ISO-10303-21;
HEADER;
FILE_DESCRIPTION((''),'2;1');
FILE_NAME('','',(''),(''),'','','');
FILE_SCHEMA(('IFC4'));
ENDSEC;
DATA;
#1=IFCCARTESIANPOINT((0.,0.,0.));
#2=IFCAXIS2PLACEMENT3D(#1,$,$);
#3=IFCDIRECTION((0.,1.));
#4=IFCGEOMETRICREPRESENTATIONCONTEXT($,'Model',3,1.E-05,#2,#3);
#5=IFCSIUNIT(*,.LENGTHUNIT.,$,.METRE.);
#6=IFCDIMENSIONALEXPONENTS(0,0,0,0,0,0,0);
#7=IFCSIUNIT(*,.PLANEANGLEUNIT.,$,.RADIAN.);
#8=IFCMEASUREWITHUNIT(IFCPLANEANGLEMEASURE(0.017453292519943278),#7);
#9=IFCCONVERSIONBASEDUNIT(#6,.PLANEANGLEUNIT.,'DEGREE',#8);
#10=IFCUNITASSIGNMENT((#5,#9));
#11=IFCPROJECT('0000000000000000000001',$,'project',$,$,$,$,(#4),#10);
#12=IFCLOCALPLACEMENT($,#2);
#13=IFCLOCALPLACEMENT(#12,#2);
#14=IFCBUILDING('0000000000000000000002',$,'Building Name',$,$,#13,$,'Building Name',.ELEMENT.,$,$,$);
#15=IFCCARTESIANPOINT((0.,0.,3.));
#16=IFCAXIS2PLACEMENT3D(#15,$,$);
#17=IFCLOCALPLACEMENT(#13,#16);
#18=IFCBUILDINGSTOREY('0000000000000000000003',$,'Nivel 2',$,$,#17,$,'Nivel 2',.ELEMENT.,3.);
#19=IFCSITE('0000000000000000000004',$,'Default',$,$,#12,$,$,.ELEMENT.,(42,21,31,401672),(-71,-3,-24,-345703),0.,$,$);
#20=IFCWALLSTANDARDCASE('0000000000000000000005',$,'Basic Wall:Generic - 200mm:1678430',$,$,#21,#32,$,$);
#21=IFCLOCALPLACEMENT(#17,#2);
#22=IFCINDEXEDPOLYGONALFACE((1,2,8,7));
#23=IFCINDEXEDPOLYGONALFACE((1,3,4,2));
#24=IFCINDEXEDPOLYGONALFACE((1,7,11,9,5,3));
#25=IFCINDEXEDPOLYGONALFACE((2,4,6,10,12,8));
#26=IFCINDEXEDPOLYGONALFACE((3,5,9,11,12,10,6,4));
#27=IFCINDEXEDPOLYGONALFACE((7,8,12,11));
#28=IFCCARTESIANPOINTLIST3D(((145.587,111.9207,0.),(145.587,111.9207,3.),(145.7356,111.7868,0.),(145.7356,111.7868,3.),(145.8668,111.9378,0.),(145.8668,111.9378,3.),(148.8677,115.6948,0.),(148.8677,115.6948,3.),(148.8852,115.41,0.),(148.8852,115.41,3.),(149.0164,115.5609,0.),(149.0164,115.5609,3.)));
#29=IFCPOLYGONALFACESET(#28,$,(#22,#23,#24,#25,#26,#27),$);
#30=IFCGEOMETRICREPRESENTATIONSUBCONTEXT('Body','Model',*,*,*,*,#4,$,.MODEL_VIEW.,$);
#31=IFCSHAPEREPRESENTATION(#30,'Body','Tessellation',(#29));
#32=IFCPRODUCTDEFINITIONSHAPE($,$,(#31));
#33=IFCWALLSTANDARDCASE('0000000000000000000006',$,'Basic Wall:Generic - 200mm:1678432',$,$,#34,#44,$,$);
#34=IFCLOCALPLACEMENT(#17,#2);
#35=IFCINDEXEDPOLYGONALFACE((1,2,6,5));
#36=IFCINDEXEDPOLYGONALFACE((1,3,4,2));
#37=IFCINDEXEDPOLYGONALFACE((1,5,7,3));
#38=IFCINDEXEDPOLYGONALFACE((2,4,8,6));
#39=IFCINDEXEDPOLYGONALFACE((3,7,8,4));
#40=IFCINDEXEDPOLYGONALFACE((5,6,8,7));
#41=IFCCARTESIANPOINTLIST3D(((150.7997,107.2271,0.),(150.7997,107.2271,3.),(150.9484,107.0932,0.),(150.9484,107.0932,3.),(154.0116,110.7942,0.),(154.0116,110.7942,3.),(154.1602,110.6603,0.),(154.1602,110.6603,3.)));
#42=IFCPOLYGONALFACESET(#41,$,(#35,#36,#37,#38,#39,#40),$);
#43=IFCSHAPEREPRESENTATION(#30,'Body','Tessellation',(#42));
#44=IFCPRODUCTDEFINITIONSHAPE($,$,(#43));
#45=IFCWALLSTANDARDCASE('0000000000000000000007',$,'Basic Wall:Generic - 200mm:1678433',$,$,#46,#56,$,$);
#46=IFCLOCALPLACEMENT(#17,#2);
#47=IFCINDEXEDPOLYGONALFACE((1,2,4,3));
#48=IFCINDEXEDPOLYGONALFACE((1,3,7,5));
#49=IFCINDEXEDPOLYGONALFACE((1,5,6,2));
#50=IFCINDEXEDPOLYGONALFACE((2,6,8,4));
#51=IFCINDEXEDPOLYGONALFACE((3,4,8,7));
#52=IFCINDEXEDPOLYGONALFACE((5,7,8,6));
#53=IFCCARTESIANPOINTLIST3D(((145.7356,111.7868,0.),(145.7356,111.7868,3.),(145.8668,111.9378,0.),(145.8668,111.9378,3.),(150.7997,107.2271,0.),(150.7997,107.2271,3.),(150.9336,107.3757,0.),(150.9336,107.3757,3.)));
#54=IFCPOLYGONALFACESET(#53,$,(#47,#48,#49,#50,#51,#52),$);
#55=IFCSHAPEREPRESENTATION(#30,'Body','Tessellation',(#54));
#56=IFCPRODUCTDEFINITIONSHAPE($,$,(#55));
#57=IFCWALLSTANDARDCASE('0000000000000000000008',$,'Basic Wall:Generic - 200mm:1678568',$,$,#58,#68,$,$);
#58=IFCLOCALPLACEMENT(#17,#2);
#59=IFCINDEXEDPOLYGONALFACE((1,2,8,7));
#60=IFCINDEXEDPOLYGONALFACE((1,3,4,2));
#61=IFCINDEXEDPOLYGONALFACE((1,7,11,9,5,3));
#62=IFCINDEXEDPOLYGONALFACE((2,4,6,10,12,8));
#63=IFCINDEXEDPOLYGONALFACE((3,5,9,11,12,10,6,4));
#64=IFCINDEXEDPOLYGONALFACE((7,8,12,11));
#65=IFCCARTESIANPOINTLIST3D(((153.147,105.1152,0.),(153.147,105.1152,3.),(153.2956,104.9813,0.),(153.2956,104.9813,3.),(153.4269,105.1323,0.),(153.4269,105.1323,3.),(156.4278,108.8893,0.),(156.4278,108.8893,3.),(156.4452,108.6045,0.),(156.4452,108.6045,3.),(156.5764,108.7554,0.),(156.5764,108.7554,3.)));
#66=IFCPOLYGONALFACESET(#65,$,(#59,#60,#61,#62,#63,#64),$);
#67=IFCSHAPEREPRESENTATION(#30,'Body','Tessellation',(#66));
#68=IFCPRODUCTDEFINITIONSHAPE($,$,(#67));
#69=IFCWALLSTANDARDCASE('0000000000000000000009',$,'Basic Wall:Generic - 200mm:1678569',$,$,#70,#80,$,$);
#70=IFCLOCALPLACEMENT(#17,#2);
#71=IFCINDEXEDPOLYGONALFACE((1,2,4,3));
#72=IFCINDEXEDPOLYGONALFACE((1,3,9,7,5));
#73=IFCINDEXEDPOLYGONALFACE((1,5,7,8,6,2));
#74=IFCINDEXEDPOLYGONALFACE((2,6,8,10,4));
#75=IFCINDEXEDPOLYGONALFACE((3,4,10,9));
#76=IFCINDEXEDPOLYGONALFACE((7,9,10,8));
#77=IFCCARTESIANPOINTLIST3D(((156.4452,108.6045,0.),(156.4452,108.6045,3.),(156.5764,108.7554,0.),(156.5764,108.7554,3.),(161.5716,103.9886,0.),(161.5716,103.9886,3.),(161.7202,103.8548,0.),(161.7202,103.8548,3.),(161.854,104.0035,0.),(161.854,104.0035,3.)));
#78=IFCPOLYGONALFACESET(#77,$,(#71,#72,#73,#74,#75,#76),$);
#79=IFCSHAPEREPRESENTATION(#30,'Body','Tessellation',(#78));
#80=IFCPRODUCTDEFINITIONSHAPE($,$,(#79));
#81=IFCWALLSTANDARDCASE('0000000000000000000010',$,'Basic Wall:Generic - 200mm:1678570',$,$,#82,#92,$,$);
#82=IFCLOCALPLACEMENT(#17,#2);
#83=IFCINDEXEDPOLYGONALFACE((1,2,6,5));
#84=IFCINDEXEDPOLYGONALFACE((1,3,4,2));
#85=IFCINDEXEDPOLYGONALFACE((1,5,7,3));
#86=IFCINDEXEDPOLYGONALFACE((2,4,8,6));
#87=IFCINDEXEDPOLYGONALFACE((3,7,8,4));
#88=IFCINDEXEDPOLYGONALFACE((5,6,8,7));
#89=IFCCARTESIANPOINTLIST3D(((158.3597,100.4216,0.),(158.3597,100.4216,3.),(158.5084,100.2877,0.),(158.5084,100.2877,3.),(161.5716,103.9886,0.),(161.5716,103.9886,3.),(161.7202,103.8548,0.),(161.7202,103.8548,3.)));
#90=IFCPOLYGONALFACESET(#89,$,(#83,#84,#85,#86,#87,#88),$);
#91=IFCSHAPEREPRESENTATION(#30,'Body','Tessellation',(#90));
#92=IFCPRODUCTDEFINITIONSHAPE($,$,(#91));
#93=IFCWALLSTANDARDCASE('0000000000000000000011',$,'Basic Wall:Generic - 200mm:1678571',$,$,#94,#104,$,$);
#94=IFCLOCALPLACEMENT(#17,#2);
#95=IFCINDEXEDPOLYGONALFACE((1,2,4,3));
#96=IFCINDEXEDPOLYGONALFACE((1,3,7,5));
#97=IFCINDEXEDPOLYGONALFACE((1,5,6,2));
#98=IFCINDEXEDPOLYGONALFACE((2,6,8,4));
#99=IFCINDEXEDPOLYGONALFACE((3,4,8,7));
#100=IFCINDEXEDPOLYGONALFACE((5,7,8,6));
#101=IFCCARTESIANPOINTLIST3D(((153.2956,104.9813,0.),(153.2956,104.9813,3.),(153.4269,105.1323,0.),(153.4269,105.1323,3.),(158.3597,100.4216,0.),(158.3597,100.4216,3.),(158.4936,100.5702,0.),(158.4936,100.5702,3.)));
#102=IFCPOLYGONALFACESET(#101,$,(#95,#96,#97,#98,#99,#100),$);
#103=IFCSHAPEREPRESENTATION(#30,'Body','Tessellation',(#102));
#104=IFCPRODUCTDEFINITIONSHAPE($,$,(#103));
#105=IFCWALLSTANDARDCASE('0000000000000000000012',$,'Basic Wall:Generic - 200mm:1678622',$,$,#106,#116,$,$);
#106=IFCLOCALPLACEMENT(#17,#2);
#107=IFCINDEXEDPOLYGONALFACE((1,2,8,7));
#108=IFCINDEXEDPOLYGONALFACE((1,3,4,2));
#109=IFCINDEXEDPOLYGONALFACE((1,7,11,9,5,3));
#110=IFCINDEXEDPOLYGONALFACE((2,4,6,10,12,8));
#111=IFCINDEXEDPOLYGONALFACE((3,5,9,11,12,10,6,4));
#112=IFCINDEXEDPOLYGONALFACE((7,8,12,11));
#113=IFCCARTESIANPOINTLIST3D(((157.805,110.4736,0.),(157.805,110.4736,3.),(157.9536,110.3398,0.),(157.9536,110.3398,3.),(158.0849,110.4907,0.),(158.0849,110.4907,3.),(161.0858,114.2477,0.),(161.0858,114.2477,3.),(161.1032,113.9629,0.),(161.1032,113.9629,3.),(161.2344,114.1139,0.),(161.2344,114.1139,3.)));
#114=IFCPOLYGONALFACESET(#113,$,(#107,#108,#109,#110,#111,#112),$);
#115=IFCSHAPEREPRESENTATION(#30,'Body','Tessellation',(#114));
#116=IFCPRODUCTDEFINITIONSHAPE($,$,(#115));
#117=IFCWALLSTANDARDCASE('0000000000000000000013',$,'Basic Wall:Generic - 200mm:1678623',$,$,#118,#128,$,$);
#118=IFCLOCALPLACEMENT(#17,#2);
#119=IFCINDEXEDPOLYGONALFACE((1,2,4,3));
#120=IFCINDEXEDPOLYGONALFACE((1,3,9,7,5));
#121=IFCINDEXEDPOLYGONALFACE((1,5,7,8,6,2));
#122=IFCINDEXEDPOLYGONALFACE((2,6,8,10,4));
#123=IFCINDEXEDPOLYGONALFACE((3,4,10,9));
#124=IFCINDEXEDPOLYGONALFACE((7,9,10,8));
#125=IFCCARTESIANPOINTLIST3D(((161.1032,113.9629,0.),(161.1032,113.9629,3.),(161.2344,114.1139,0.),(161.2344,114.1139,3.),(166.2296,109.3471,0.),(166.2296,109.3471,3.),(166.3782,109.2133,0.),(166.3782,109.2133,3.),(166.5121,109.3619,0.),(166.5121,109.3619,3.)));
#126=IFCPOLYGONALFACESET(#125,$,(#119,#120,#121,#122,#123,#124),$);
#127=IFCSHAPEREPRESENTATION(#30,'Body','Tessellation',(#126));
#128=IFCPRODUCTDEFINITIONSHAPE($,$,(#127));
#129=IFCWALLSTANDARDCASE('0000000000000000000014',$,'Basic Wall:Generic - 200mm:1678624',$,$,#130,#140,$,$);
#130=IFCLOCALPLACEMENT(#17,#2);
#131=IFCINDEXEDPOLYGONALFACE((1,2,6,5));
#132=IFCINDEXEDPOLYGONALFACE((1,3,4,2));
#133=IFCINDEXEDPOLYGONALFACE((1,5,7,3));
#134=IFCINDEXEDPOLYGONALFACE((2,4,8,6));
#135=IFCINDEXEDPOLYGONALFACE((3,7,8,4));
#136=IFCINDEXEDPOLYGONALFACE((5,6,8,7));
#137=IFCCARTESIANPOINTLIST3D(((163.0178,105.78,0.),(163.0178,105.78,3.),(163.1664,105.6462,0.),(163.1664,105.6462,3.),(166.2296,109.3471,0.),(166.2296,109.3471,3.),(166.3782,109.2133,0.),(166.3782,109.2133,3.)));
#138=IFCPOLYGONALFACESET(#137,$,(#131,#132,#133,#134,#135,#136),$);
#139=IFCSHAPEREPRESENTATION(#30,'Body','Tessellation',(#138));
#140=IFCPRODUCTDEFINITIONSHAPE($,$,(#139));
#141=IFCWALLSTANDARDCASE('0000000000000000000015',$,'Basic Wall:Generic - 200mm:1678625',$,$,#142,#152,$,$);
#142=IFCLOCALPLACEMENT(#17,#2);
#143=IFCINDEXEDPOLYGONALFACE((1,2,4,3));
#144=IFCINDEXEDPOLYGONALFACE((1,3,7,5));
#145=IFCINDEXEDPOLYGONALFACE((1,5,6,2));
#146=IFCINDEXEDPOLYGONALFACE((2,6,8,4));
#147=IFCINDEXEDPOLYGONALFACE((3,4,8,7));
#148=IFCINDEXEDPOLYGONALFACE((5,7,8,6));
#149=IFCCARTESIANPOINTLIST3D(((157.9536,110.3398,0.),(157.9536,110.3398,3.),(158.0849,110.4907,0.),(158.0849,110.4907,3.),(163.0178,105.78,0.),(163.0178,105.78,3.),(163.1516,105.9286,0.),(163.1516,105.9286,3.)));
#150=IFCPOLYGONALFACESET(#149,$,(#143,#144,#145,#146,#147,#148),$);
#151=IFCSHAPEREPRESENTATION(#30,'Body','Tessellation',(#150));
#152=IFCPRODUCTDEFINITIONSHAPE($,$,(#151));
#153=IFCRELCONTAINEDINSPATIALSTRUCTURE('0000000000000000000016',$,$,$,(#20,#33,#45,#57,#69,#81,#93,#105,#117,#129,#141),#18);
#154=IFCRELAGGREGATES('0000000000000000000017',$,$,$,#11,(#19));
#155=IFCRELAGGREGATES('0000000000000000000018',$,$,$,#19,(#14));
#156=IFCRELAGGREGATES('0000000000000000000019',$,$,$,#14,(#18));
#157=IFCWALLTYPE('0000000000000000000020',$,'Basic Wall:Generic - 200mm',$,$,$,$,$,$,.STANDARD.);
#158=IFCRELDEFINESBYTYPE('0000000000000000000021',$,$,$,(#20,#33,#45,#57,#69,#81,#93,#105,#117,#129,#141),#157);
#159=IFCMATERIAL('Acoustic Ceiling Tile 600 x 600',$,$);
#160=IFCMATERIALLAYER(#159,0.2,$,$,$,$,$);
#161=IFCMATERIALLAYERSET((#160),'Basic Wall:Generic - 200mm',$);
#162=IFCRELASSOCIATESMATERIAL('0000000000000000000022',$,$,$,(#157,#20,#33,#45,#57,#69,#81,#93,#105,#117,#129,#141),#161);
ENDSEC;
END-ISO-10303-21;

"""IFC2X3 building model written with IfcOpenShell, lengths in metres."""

from ifc_helpers import new_model, entity, si_unit, converted_unit, direction, frame, frame_2d, origin, place, context, subcontext, project, spatial, polyline, rectangle, outline, extrude, material, layer, layer_set, layer_usage, type_object, element, save


model = new_model("IFC2X3")

# Units and contexts
model_context = context("Model", 3, precision=1e-05, world=origin(), true_north=direction((0.0, 1.0)))
body_context = subcontext(model_context, "Body", "Model", "MODEL_VIEW")
ifc_project = project(units=[si_unit("LENGTHUNIT", "METRE"), converted_unit("PLANEANGLEUNIT", "DEGREE", entity("IfcPlaneAngleMeasure", 0.017453292519943278), si_unit("PLANEANGLEUNIT", "RADIAN"), dimensions=[0, 0, 0, 0, 0, 0, 0])], contexts=[model_context])

# Site, building, storey
site_placement = place(None, origin())
site = spatial("IfcSite", under=ifc_project, at=site_placement, Name="Default", CompositionType="ELEMENT", RefLatitude=(42, 21, 31, 401672), RefLongitude=(-71, -3, -24, -345703), RefElevation=0.0)
building_placement = place(site_placement, origin())
building = spatial("IfcBuilding", under=site, at=building_placement, Name="Building Name", LongName="Building Name", CompositionType="ELEMENT")
storey_placement = place(building_placement, frame((0.0, 0.0, 3.0)))
storey = spatial("IfcBuildingStorey", under=building, at=storey_placement, Name="Nivel 2", LongName="Nivel 2", CompositionType="ELEMENT", Elevation=3.0)

# Shared definitions
ifc_material_1 = material(Name="Acoustic Ceiling Tile 600 x 600")
ifc_layer_1 = layer(ifc_material_1, 0.2)
ifc_layer_set_1 = layer_set([ifc_layer_1], Name="Basic Wall:Generic - 200mm")
wall_type_1 = type_object("IfcWallType", Name="Basic Wall:Generic - 200mm", PredefinedType="STANDARD", material=ifc_layer_set_1)

# Walls
ifc_layer_usage_1 = layer_usage(ifc_layer_set_1, "AXIS2", "NEGATIVE", 0.1)
wall_1_placement = place(storey_placement, frame((145.6601, 111.8524, 0.0), z_axis=(0.0, 0.0, 1.0), x_axis=(0.656059, 0.75471, 0.0)))
element("IfcWallStandardCase", 1, at=wall_1_placement, inside=storey, type_object=wall_type_1, material=ifc_layer_usage_1, Name="Basic Wall:Generic - 200mm:1678430", context=body_context, shape_type="SweptSolid", body=[
    extrude(outline(polyline([(5.0008, -0.1), (5.0043, 0.1), (0.0035, 0.1), (0.0, -0.1), (0.2, -0.1), (4.8007, -0.1), (5.0008, -0.1)])), origin(), (0.0, 0.0, 1.0), 3.0),
])
ifc_layer_usage_2 = layer_usage(ifc_layer_set_1, "AXIS2", "NEGATIVE", 0.1)
wall_2_placement = place(storey_placement, frame((154.0859, 110.7272, 0.0), z_axis=(0.0, 0.0, 1.0), x_axis=(-0.669131, -0.743145, 0.0)))
element("IfcWallStandardCase", 2, at=wall_2_placement, inside=storey, type_object=wall_type_1, material=ifc_layer_usage_2, Name="Basic Wall:Generic - 200mm:1678432", context=body_context, shape_type="SweptSolid", body=[
    extrude(rectangle(XDim=4.8, YDim=0.2, at=frame_2d((2.4, 0.0), x_axis=(-1.0, 0.0))), origin(), (0.0, 0.0, 1.0), 3.0),
])
ifc_layer_usage_3 = layer_usage(ifc_layer_set_1, "AXIS2", "NEGATIVE", 0.1)
wall_3_placement = place(storey_placement, frame((150.8666, 107.3014, 0.0), z_axis=(0.0, 0.0, 1.0), x_axis=(-0.743145, 0.669131, 0.0)))
element("IfcWallStandardCase", 3, at=wall_3_placement, inside=storey, type_object=wall_type_1, material=ifc_layer_usage_3, Name="Basic Wall:Generic - 200mm:1678433", context=body_context, shape_type="SweptSolid", body=[
    extrude(outline(polyline([(6.8179, -0.1), (6.8145, 0.1), (0.0, 0.1), (0.0, -0.1), (6.8179, -0.1)])), origin(), (0.0, 0.0, 1.0), 3.0),
])
ifc_layer_usage_4 = layer_usage(ifc_layer_set_1, "AXIS2", "NEGATIVE", 0.1)
wall_4_placement = place(storey_placement, frame((153.2202, 105.0469, 0.0), z_axis=(0.0, 0.0, 1.0), x_axis=(0.656059, 0.75471, 0.0)))
element("IfcWallStandardCase", 4, at=wall_4_placement, inside=storey, type_object=wall_type_1, material=ifc_layer_usage_4, Name="Basic Wall:Generic - 200mm:1678568", context=body_context, shape_type="SweptSolid", body=[
    extrude(outline(polyline([(5.0008, -0.1), (5.0043, 0.1), (0.0035, 0.1), (0.0, -0.1), (0.2, -0.1), (4.8007, -0.1), (5.0008, -0.1)])), origin(), (0.0, 0.0, 1.0), 3.0),
])
ifc_layer_usage_5 = layer_usage(ifc_layer_set_1, "AXIS2", "NEGATIVE", 0.1)
wall_5_placement = place(storey_placement, frame((156.5095, 108.6811, 0.0), z_axis=(0.0, 0.0, 1.0), x_axis=(0.743145, -0.669131, 0.0)))
element("IfcWallStandardCase", 5, at=wall_5_placement, inside=storey, type_object=wall_type_1, material=ifc_layer_usage_5, Name="Basic Wall:Generic - 200mm:1678569", context=body_context, shape_type="SweptSolid", body=[
    extrude(outline(polyline([(7.1017, -0.1), (7.1017, 0.1), (0.0, 0.1), (0.0035, -0.1), (6.9017, -0.1), (7.1017, -0.1)])), origin(), (0.0, 0.0, 1.0), 3.0),
])
ifc_layer_usage_6 = layer_usage(ifc_layer_set_1, "AXIS2", "NEGATIVE", 0.1)
wall_6_placement = place(storey_placement, frame((161.6459, 103.9217, 0.0), z_axis=(0.0, 0.0, 1.0), x_axis=(-0.669131, -0.743145, 0.0)))
element("IfcWallStandardCase", 6, at=wall_6_placement, inside=storey, type_object=wall_type_1, material=ifc_layer_usage_6, Name="Basic Wall:Generic - 200mm:1678570", context=body_context, shape_type="SweptSolid", body=[
    extrude(rectangle(XDim=4.8, YDim=0.2, at=frame_2d((2.4, 0.0), x_axis=(-1.0, 0.0))), origin(), (0.0, 0.0, 1.0), 3.0),
])
ifc_layer_usage_7 = layer_usage(ifc_layer_set_1, "AXIS2", "NEGATIVE", 0.1)
wall_7_placement = place(storey_placement, frame((158.4267, 100.4959, 0.0), z_axis=(0.0, 0.0, 1.0), x_axis=(-0.743145, 0.669131, 0.0)))
element("IfcWallStandardCase", 7, at=wall_7_placement, inside=storey, type_object=wall_type_1, material=ifc_layer_usage_7, Name="Basic Wall:Generic - 200mm:1678571", context=body_context, shape_type="SweptSolid", body=[
    extrude(outline(polyline([(6.8179, -0.1), (6.8145, 0.1), (0.0, 0.1), (0.0, -0.1), (6.8179, -0.1)])), origin(), (0.0, 0.0, 1.0), 3.0),
])
ifc_layer_usage_8 = layer_usage(ifc_layer_set_1, "AXIS2", "NEGATIVE", 0.1)
wall_8_placement = place(storey_placement, frame((157.8782, 110.4054, 0.0), z_axis=(0.0, 0.0, 1.0), x_axis=(0.656059, 0.75471, 0.0)))
element("IfcWallStandardCase", 8, at=wall_8_placement, inside=storey, type_object=wall_type_1, material=ifc_layer_usage_8, Name="Basic Wall:Generic - 200mm:1678622", context=body_context, shape_type="SweptSolid", body=[
    extrude(outline(polyline([(5.0008, -0.1), (5.0043, 0.1), (0.0035, 0.1), (0.0, -0.1), (0.2, -0.1), (4.8007, -0.1), (5.0008, -0.1)])), origin(), (0.0, 0.0, 1.0), 3.0),
])
ifc_layer_usage_9 = layer_usage(ifc_layer_set_1, "AXIS2", "NEGATIVE", 0.1)
wall_9_placement = place(storey_placement, frame((161.1675, 114.0396, 0.0), z_axis=(0.0, 0.0, 1.0), x_axis=(0.743145, -0.669131, 0.0)))
element("IfcWallStandardCase", 9, at=wall_9_placement, inside=storey, type_object=wall_type_1, material=ifc_layer_usage_9, Name="Basic Wall:Generic - 200mm:1678623", context=body_context, shape_type="SweptSolid", body=[
    extrude(outline(polyline([(7.1017, -0.1), (7.1017, 0.1), (0.0, 0.1), (0.0035, -0.1), (6.9017, -0.1), (7.1017, -0.1)])), origin(), (0.0, 0.0, 1.0), 3.0),
])
ifc_layer_usage_10 = layer_usage(ifc_layer_set_1, "AXIS2", "NEGATIVE", 0.1)
wall_10_placement = place(storey_placement, frame((166.3039, 109.2802, 0.0), z_axis=(0.0, 0.0, 1.0), x_axis=(-0.669131, -0.743145, 0.0)))
element("IfcWallStandardCase", 10, at=wall_10_placement, inside=storey, type_object=wall_type_1, material=ifc_layer_usage_10, Name="Basic Wall:Generic - 200mm:1678624", context=body_context, shape_type="SweptSolid", body=[
    extrude(rectangle(XDim=4.8, YDim=0.2, at=frame_2d((2.4, 0.0), x_axis=(-1.0, 0.0))), origin(), (0.0, 0.0, 1.0), 3.0),
])
ifc_layer_usage_11 = layer_usage(ifc_layer_set_1, "AXIS2", "NEGATIVE", 0.1)
wall_11_placement = place(storey_placement, frame((163.0847, 105.8543, 0.0), z_axis=(0.0, 0.0, 1.0), x_axis=(-0.743145, 0.669131, 0.0)))
element("IfcWallStandardCase", 11, at=wall_11_placement, inside=storey, type_object=wall_type_1, material=ifc_layer_usage_11, Name="Basic Wall:Generic - 200mm:1678625", context=body_context, shape_type="SweptSolid", body=[
    extrude(outline(polyline([(6.8179, -0.1), (6.8145, 0.1), (0.0, 0.1), (0.0, -0.1), (6.8179, -0.1)])), origin(), (0.0, 0.0, 1.0), 3.0),
])

save(model, "model.ifc")
